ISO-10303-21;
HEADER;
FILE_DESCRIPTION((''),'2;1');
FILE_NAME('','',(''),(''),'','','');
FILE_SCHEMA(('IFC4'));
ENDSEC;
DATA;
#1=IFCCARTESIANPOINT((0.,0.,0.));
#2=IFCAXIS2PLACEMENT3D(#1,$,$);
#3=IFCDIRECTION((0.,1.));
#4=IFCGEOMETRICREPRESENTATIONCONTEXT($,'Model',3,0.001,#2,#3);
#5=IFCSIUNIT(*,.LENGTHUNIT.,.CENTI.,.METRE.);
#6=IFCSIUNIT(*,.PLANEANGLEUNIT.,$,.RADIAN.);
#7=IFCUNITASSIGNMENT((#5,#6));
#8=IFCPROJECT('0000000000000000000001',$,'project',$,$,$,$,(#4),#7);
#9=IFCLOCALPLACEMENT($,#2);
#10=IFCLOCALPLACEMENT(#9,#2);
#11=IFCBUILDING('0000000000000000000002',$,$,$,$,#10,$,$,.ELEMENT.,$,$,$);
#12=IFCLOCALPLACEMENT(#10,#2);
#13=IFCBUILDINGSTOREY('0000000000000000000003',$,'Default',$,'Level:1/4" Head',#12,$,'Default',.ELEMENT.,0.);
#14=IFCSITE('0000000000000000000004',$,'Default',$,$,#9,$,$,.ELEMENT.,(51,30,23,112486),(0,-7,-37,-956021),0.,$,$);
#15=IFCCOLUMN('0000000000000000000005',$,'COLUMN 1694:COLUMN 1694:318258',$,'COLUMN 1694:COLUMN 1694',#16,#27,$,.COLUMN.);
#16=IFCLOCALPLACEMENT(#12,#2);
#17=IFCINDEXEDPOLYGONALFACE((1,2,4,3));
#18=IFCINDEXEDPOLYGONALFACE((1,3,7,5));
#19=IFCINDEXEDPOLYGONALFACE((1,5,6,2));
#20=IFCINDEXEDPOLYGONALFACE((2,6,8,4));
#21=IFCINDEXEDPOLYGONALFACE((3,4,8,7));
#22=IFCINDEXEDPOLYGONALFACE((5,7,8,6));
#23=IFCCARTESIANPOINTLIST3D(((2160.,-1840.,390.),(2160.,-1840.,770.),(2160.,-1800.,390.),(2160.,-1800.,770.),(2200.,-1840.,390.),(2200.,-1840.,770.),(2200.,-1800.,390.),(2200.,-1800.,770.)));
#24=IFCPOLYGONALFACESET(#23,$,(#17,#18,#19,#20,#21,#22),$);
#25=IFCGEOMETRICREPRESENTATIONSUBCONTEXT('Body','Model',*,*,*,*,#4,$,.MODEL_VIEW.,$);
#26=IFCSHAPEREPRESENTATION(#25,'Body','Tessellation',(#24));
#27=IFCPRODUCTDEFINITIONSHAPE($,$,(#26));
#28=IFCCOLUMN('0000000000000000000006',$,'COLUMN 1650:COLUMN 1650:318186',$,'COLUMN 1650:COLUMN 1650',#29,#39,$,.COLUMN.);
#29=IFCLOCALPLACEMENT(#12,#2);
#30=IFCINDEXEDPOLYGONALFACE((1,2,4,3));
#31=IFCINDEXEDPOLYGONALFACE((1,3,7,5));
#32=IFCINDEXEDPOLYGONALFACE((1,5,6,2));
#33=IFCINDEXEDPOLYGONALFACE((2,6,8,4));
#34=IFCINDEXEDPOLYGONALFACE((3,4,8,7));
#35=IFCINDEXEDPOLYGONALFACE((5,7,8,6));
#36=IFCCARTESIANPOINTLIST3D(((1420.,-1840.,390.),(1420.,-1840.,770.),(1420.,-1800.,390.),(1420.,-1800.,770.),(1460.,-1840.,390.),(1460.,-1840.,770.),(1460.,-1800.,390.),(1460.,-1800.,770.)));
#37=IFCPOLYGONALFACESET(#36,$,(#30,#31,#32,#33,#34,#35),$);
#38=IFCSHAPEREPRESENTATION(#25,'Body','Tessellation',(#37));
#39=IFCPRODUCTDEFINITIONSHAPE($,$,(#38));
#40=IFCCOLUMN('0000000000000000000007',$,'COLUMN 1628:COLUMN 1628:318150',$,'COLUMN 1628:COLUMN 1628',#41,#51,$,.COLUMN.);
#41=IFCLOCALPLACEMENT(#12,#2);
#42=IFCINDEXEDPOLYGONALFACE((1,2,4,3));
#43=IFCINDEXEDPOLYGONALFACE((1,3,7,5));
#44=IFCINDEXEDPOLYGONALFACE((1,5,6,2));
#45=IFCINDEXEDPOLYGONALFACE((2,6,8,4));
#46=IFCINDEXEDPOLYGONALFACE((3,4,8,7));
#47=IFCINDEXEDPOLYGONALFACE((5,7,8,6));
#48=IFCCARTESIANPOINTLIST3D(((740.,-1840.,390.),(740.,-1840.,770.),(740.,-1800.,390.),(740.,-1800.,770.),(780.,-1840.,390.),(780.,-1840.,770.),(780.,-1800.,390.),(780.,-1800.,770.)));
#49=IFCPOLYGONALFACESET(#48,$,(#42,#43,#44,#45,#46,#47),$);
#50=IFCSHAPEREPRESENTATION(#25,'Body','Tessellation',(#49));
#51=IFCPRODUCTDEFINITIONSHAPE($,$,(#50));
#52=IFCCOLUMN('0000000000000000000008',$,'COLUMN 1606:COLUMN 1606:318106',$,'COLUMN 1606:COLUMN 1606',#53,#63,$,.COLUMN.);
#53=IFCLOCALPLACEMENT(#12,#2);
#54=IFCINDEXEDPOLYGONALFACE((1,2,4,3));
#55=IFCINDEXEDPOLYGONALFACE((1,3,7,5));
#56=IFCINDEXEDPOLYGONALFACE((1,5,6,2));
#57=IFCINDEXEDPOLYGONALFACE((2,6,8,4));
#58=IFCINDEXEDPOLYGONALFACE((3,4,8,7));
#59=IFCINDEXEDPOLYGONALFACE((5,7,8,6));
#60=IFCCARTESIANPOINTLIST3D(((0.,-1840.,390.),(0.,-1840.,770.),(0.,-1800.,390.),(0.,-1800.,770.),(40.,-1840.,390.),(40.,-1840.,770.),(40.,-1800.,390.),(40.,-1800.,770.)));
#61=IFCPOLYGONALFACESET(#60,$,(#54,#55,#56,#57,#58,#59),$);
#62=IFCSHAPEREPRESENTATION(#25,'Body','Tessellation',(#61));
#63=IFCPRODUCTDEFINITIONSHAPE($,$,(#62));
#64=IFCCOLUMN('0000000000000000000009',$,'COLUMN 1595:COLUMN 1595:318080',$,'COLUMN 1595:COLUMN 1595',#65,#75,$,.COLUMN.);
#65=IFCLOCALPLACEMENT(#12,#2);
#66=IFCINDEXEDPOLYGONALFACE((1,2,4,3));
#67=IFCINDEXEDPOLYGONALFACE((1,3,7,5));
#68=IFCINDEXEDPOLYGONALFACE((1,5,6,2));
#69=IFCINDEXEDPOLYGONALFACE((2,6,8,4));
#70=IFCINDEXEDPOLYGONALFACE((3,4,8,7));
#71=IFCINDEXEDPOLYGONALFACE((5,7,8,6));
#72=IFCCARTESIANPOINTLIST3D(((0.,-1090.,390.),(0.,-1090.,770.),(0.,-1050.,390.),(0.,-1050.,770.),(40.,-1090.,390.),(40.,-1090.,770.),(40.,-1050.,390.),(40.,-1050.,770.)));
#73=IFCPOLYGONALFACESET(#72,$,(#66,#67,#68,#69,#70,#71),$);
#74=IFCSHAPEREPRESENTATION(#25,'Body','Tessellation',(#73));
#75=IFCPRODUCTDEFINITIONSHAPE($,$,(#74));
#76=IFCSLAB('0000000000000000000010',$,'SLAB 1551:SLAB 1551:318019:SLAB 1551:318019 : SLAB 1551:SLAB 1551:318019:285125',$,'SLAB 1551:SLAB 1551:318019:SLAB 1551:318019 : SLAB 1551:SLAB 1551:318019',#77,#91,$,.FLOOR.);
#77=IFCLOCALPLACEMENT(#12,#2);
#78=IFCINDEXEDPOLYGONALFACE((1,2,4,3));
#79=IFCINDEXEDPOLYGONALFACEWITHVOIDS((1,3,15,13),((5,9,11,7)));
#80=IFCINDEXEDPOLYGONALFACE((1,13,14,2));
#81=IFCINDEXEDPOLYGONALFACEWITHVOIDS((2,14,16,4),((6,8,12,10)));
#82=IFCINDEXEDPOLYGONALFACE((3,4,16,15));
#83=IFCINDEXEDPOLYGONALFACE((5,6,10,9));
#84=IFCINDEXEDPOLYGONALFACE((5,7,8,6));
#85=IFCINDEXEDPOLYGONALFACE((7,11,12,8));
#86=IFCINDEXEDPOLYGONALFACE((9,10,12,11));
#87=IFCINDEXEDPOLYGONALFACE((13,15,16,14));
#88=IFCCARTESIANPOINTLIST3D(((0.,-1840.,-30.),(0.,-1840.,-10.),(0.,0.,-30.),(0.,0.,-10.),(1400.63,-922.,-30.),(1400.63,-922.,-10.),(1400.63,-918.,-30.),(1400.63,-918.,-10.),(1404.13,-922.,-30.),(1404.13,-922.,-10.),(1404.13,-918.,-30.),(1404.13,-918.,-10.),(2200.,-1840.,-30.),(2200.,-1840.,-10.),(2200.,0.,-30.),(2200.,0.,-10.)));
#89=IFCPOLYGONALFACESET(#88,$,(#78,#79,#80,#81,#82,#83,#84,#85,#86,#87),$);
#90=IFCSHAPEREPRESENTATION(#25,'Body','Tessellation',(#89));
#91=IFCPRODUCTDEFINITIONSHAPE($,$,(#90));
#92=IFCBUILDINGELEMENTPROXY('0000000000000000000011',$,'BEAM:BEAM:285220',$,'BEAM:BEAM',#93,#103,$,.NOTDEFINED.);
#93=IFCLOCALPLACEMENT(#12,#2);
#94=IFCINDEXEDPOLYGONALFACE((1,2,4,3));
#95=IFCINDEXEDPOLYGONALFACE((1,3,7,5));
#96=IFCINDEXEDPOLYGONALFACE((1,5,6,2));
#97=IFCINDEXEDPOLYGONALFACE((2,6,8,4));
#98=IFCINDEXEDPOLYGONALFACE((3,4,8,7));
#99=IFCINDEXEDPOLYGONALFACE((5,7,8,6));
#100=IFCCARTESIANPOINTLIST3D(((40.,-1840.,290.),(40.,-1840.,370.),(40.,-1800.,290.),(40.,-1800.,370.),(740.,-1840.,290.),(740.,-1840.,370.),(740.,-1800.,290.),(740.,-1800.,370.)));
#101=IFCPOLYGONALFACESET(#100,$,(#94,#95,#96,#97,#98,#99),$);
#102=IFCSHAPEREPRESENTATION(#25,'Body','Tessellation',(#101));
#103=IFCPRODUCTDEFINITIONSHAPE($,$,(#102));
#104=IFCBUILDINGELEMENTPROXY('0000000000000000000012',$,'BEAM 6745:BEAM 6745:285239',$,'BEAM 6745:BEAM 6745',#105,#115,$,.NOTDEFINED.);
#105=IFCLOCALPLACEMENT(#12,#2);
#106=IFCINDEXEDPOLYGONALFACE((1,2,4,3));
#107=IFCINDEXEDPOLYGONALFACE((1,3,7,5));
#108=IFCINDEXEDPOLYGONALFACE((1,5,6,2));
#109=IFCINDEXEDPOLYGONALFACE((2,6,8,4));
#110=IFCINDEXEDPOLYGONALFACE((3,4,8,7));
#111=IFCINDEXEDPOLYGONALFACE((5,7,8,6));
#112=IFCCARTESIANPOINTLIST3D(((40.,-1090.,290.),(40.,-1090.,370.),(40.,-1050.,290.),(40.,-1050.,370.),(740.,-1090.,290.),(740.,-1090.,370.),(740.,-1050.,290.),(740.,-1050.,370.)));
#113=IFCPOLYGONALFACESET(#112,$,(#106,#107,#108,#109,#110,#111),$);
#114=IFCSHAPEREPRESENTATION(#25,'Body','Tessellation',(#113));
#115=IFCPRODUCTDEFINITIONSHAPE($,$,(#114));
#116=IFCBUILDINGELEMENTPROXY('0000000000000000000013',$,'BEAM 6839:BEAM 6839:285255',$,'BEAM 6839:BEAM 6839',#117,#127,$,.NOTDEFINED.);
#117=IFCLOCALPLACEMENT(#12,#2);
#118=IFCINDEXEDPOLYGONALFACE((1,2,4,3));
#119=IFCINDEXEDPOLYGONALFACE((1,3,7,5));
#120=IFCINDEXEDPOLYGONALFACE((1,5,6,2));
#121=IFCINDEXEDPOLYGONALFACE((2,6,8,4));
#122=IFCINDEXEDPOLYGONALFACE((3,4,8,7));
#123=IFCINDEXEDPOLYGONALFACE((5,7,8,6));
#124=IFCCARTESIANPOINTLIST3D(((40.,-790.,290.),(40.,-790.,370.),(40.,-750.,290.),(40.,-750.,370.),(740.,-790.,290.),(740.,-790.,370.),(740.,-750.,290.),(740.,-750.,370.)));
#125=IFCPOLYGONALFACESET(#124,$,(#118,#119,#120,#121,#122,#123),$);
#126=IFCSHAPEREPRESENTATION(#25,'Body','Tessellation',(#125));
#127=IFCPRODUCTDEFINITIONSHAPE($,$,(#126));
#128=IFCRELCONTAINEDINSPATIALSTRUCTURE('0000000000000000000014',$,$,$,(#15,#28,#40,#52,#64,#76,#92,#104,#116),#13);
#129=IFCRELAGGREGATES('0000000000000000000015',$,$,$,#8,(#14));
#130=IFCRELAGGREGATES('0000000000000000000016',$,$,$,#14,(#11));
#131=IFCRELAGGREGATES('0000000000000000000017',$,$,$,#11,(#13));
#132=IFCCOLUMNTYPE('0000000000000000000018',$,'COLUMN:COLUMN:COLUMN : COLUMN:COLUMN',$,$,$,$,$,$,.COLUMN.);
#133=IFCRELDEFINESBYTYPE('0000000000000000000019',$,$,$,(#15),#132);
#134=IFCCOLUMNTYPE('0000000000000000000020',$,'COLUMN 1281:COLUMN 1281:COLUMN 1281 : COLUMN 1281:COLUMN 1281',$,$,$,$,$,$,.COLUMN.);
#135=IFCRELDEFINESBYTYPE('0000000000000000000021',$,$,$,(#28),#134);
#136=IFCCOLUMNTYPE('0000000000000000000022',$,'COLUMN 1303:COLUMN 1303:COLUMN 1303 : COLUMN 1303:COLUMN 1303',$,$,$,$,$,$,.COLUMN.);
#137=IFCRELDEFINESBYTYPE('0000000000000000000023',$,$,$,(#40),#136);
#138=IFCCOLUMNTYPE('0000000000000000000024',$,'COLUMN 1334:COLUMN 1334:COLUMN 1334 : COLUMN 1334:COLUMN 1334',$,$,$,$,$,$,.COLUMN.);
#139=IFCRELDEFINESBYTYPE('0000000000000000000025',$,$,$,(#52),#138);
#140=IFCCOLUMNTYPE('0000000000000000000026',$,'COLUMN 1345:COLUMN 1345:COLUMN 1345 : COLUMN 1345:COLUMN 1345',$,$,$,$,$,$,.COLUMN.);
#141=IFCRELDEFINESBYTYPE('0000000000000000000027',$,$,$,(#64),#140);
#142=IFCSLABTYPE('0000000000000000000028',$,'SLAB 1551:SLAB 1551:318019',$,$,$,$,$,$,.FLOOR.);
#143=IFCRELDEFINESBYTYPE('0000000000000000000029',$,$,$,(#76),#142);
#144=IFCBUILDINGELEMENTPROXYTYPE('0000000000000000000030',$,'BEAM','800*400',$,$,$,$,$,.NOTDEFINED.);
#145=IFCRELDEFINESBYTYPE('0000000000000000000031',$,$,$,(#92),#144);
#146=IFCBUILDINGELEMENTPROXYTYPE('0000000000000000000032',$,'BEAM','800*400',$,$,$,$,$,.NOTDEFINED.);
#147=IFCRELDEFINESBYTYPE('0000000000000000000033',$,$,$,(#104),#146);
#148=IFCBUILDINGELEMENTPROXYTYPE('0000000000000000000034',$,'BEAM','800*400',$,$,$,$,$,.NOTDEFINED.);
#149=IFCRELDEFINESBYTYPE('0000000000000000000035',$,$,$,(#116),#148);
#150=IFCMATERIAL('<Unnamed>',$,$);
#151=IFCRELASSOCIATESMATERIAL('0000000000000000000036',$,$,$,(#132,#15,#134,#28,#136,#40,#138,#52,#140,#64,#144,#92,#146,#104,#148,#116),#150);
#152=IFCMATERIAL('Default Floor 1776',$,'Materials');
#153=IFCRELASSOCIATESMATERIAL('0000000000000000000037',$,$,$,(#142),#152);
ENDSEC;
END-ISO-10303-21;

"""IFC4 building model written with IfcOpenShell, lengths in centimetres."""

from ifc_helpers import new_model, si_unit, direction, frame, frame_2d, origin, origin_2d_with_axis, place, context, subcontext, project, spatial, polyline, segment, composite_curve, rectangle, outline, extrude, source, transform, mapped, material, material_profile, profile_set, profile_usage, type_object, type_shapes, element, save


model = new_model("IFC4")

# Units and contexts
model_context = context("Model", 3, precision=0.001, world=origin(), true_north=direction((0.0, 1.0)))
body_context = subcontext(model_context, "Body", "Model", "MODEL_VIEW")
ifc_project = project(units=[si_unit("LENGTHUNIT", "METRE", prefix="CENTI"), si_unit("PLANEANGLEUNIT", "RADIAN")], contexts=[model_context])

# Site, building, storey
site_placement = place(None, origin())
site = spatial("IfcSite", under=ifc_project, at=site_placement, Name="Default", CompositionType="ELEMENT", RefLatitude=(51, 30, 23, 112486), RefLongitude=(0, -7, -37, -956021), RefElevation=0.0)
building_placement = place(site_placement, origin())
building = spatial("IfcBuilding", under=site, at=building_placement, CompositionType="ELEMENT")
storey_placement = place(building_placement, origin())
storey = spatial("IfcBuildingStorey", under=building, at=storey_placement, Name="Default", ObjectType="Level:1/4\" Head", LongName="Default", CompositionType="ELEMENT", Elevation=0.0)

# Columns
ifc_material_1 = material(Name="<Unnamed>")
ifc_material_profile_1 = material_profile(ifc_material_1, outline(composite_curve([segment(polyline([(2140.0, -20.0, 770.0), (2180.0, -20.0, 770.0)]), True, "CONTINUOUS"), segment(polyline([(2180.0, -20.0, 770.0), (2180.0, 20.0, 770.0)]), True, "CONTINUOUS"), segment(polyline([(2180.0, 20.0, 770.0), (2140.0, 20.0, 770.0)]), True, "CONTINUOUS"), segment(polyline([(2140.0, 20.0, 770.0), (2140.0, -20.0, 770.0)]), True, "CONTINUOUS")], self_intersect=False), kind="CURVE"), Name="COLUMN : COLUMN:COLUMN")
ifc_profile_set_1 = profile_set([ifc_material_profile_1], Name="COLUMN : COLUMN:COLUMN")
ifc_profile_usage_1 = profile_usage(ifc_profile_set_1)
column_type_1 = type_object("IfcColumnType", Name="COLUMN:COLUMN:COLUMN : COLUMN:COLUMN", PredefinedType="COLUMN", material=ifc_profile_set_1)
shared_shape_1 = source(origin(), body_context, "Body", "SweptSolid", [
    extrude(rectangle(XDim=40.0, YDim=40.0, at=frame_2d((0.0, 0.0), x_axis=(1.0, 0.0))), frame((2160.0, 0.0, 390.0), z_axis=(0.0, 0.0, 1.0), x_axis=(0.0, -1.0, 0.0)), (0.0, 0.0, 1.0), 380.0),
])
type_shapes(column_type_1, [shared_shape_1])
column_1_placement = place(storey_placement, frame((20.0, -1820.0, 0.0)))
element("IfcColumn", 1, at=column_1_placement, inside=storey, type_object=column_type_1, material=ifc_profile_usage_1, Name="COLUMN 1694:COLUMN 1694:318258", ObjectType="COLUMN 1694:COLUMN 1694", PredefinedType="COLUMN", context=body_context, shape_type="MappedRepresentation", body=[
    mapped(shared_shape_1, transform((0.0, 0.0, 0.0), scale=1.0)),
])
ifc_material_profile_2 = material_profile(ifc_material_1, outline(composite_curve([segment(polyline([(1400.0, -20.0, 770.0), (1440.0, -20.0, 770.0)]), True, "CONTINUOUS"), segment(polyline([(1440.0, -20.0, 770.0), (1440.0, 20.0, 770.0)]), True, "CONTINUOUS"), segment(polyline([(1440.0, 20.0, 770.0), (1400.0, 20.0, 770.0)]), True, "CONTINUOUS"), segment(polyline([(1400.0, 20.0, 770.0), (1400.0, -20.0, 770.0)]), True, "CONTINUOUS")], self_intersect=False), kind="CURVE"), Name="COLUMN 1281 : COLUMN 1281:COLUMN 1281")
ifc_profile_set_2 = profile_set([ifc_material_profile_2], Name="COLUMN 1281 : COLUMN 1281:COLUMN 1281")
ifc_profile_usage_2 = profile_usage(ifc_profile_set_2)
column_type_2 = type_object("IfcColumnType", Name="COLUMN 1281:COLUMN 1281:COLUMN 1281 : COLUMN 1281:COLUMN 1281", PredefinedType="COLUMN", material=ifc_profile_set_2)
shared_shape_2 = source(origin(), body_context, "Body", "SweptSolid", [
    extrude(rectangle(XDim=40.0, YDim=40.0, at=origin_2d_with_axis()), frame((1420.0, 0.0, 390.0), z_axis=(0.0, 0.0, 1.0), x_axis=(0.0, -1.0, 0.0)), (0.0, 0.0, 1.0), 380.0),
])
type_shapes(column_type_2, [shared_shape_2])
column_2_placement = place(storey_placement, frame((20.0, -1820.0, 0.0)))
element("IfcColumn", 2, at=column_2_placement, inside=storey, type_object=column_type_2, material=ifc_profile_usage_2, Name="COLUMN 1650:COLUMN 1650:318186", ObjectType="COLUMN 1650:COLUMN 1650", PredefinedType="COLUMN", context=body_context, shape_type="MappedRepresentation", body=[
    mapped(shared_shape_2, transform((0.0, 0.0, 0.0), scale=1.0)),
])
ifc_material_profile_3 = material_profile(ifc_material_1, outline(composite_curve([segment(polyline([(720.0, -20.0, 390.0), (720.0, 20.0, 390.0)]), True, "CONTINUOUS"), segment(polyline([(720.0, 20.0, 390.0), (760.0, 20.0, 390.0)]), True, "CONTINUOUS"), segment(polyline([(760.0, 20.0, 390.0), (760.0, -20.0, 390.0)]), True, "CONTINUOUS"), segment(polyline([(760.0, -20.0, 390.0), (720.0, -20.0, 390.0)]), True, "CONTINUOUS")], self_intersect=False), kind="CURVE"), Name="COLUMN 1303 : COLUMN 1303:COLUMN 1303")
ifc_profile_set_3 = profile_set([ifc_material_profile_3], Name="COLUMN 1303 : COLUMN 1303:COLUMN 1303")
ifc_profile_usage_3 = profile_usage(ifc_profile_set_3)
column_type_3 = type_object("IfcColumnType", Name="COLUMN 1303:COLUMN 1303:COLUMN 1303 : COLUMN 1303:COLUMN 1303", PredefinedType="COLUMN", material=ifc_profile_set_3)
shared_shape_3 = source(origin(), body_context, "Body", "SweptSolid", [
    extrude(rectangle(XDim=40.0, YDim=40.0, at=origin_2d_with_axis()), frame((740.0, 0.0, 390.0), z_axis=(0.0, 0.0, 1.0), x_axis=(0.0, -1.0, 0.0)), (0.0, 0.0, 1.0), 380.0),
])
type_shapes(column_type_3, [shared_shape_3])
column_3_placement = place(storey_placement, frame((20.0, -1820.0, 0.0)))
element("IfcColumn", 3, at=column_3_placement, inside=storey, type_object=column_type_3, material=ifc_profile_usage_3, Name="COLUMN 1628:COLUMN 1628:318150", ObjectType="COLUMN 1628:COLUMN 1628", PredefinedType="COLUMN", context=body_context, shape_type="MappedRepresentation", body=[
    mapped(shared_shape_3, transform((0.0, 0.0, 0.0), scale=1.0)),
])
ifc_material_profile_4 = material_profile(ifc_material_1, outline(composite_curve([segment(polyline([(-20.0, -20.0, 390.0), (-20.0, 20.0, 390.0)]), True, "CONTINUOUS"), segment(polyline([(-20.0, 20.0, 390.0), (20.0, 20.0, 390.0)]), True, "CONTINUOUS"), segment(polyline([(20.0, 20.0, 390.0), (20.0, -20.0, 390.0)]), True, "CONTINUOUS"), segment(polyline([(20.0, -20.0, 390.0), (-20.0, -20.0, 390.0)]), True, "CONTINUOUS")], self_intersect=False), kind="CURVE"), Name="COLUMN 1334 : COLUMN 1334:COLUMN 1334")
ifc_profile_set_4 = profile_set([ifc_material_profile_4], Name="COLUMN 1334 : COLUMN 1334:COLUMN 1334")
ifc_profile_usage_4 = profile_usage(ifc_profile_set_4)
column_type_4 = type_object("IfcColumnType", Name="COLUMN 1334:COLUMN 1334:COLUMN 1334 : COLUMN 1334:COLUMN 1334", PredefinedType="COLUMN", material=ifc_profile_set_4)
shared_shape_4 = source(origin(), body_context, "Body", "SweptSolid", [
    extrude(rectangle(XDim=40.0, YDim=40.0, at=origin_2d_with_axis()), frame((0.0, 0.0, 390.0), z_axis=(0.0, 0.0, 1.0), x_axis=(0.0, -1.0, 0.0)), (0.0, 0.0, 1.0), 380.0),
])
type_shapes(column_type_4, [shared_shape_4])
column_4_placement = place(storey_placement, frame((20.0, -1820.0, 0.0)))
element("IfcColumn", 4, at=column_4_placement, inside=storey, type_object=column_type_4, material=ifc_profile_usage_4, Name="COLUMN 1606:COLUMN 1606:318106", ObjectType="COLUMN 1606:COLUMN 1606", PredefinedType="COLUMN", context=body_context, shape_type="MappedRepresentation", body=[
    mapped(shared_shape_4, transform((0.0, 0.0, 0.0), scale=1.0)),
])
ifc_material_profile_5 = material_profile(ifc_material_1, outline(composite_curve([segment(polyline([(-20.0, 730.0, 390.0), (-20.0, 770.0, 390.0)]), True, "CONTINUOUS"), segment(polyline([(-20.0, 770.0, 390.0), (20.0, 770.0, 390.0)]), True, "CONTINUOUS"), segment(polyline([(20.0, 770.0, 390.0), (20.0, 730.0, 390.0)]), True, "CONTINUOUS"), segment(polyline([(20.0, 730.0, 390.0), (-20.0, 730.0, 390.0)]), True, "CONTINUOUS")], self_intersect=False), kind="CURVE"), Name="COLUMN 1345 : COLUMN 1345:COLUMN 1345")
ifc_profile_set_5 = profile_set([ifc_material_profile_5], Name="COLUMN 1345 : COLUMN 1345:COLUMN 1345")
ifc_profile_usage_5 = profile_usage(ifc_profile_set_5)
column_type_5 = type_object("IfcColumnType", Name="COLUMN 1345:COLUMN 1345:COLUMN 1345 : COLUMN 1345:COLUMN 1345", PredefinedType="COLUMN", material=ifc_profile_set_5)
shared_shape_5 = source(origin(), body_context, "Body", "SweptSolid", [
    extrude(rectangle(XDim=40.0, YDim=40.0, at=origin_2d_with_axis()), frame((0.0, 750.0, 390.0), z_axis=(0.0, 0.0, 1.0), x_axis=(0.0, -1.0, 0.0)), (0.0, 0.0, 1.0), 380.0),
])
type_shapes(column_type_5, [shared_shape_5])
column_5_placement = place(storey_placement, frame((20.0, -1820.0, 0.0)))
element("IfcColumn", 5, at=column_5_placement, inside=storey, type_object=column_type_5, material=ifc_profile_usage_5, Name="COLUMN 1595:COLUMN 1595:318080", ObjectType="COLUMN 1595:COLUMN 1595", PredefinedType="COLUMN", context=body_context, shape_type="MappedRepresentation", body=[
    mapped(shared_shape_5, transform((0.0, 0.0, 0.0), scale=1.0)),
])

# Slab
ifc_material_2 = material(Name="Default Floor 1776", Category="Materials")
slab_type_1 = type_object("IfcSlabType", Name="SLAB 1551:SLAB 1551:318019", PredefinedType="FLOOR", material=ifc_material_2)
slab_1_placement = place(storey_placement, frame((0.0, -1840.0, -30.0)))
element("IfcSlab", 6, at=slab_1_placement, inside=storey, type_object=slab_type_1, Name="SLAB 1551:SLAB 1551:318019:SLAB 1551:318019 : SLAB 1551:SLAB 1551:318019:285125", ObjectType="SLAB 1551:SLAB 1551:318019:SLAB 1551:318019 : SLAB 1551:SLAB 1551:318019", PredefinedType="FLOOR", context=body_context, shape_type="SweptSolid", body=[
    extrude(outline(polyline([(-920.0, -1100.0), (920.0, -1100.0), (920.0, 1100.0), (-920.0, 1100.0), (-920.0, -1100.0)]), holes=[polyline([(2.0, 300.63), (-2.0, 300.63), (-2.0, 304.13), (2.0, 304.13), (2.0, 300.63)])]), frame((1100.0, 920.0, 0.0), z_axis=(0.0, 0.0, 1.0), x_axis=(0.0, -1.0, 0.0)), (0.0, 0.0, 1.0), 20.0),
])

# Building element proxies
building_element_proxy_type_1 = type_object("IfcBuildingElementProxyType", Name="BEAM", Description="800*400", PredefinedType="NOTDEFINED", material=ifc_material_1)
shared_shape_6 = source(origin(), body_context, "Body", "SweptSolid", [
    extrude(rectangle(XDim=40.0, YDim=700.0, at=origin_2d_with_axis()), frame((350.0, 20.0, 0.0), z_axis=(0.0, 0.0, 1.0), x_axis=(0.0, 1.0, 0.0)), (0.0, 0.0, 1.0), 80.0),
])
type_shapes(building_element_proxy_type_1, [shared_shape_6])
proxy_1_placement = place(storey_placement, frame((40.0, -1840.0, 290.0)))
element("IfcBuildingElementProxy", 7, at=proxy_1_placement, inside=storey, type_object=building_element_proxy_type_1, material=ifc_material_1, Name="BEAM:BEAM:285220", ObjectType="BEAM:BEAM", PredefinedType="NOTDEFINED", context=body_context, shape_type="MappedRepresentation", body=[
    mapped(shared_shape_6, transform((0.0, 0.0, 0.0), scale=1.0)),
])
building_element_proxy_type_2 = type_object("IfcBuildingElementProxyType", Name="BEAM", Description="800*400", PredefinedType="NOTDEFINED", material=ifc_material_1)
shared_shape_7 = source(origin(), body_context, "Body", "SweptSolid", [
    extrude(rectangle(XDim=40.0, YDim=700.0, at=origin_2d_with_axis()), frame((350.0, 20.0, 0.0), z_axis=(0.0, 0.0, 1.0), x_axis=(0.0, 1.0, 0.0)), (0.0, 0.0, 1.0), 80.0),
])
type_shapes(building_element_proxy_type_2, [shared_shape_7])
proxy_2_placement = place(storey_placement, frame((40.0, -1090.0, 290.0)))
element("IfcBuildingElementProxy", 8, at=proxy_2_placement, inside=storey, type_object=building_element_proxy_type_2, material=ifc_material_1, Name="BEAM 6745:BEAM 6745:285239", ObjectType="BEAM 6745:BEAM 6745", PredefinedType="NOTDEFINED", context=body_context, shape_type="MappedRepresentation", body=[
    mapped(shared_shape_7, transform((0.0, 0.0, 0.0), scale=1.0)),
])
building_element_proxy_type_3 = type_object("IfcBuildingElementProxyType", Name="BEAM", Description="800*400", PredefinedType="NOTDEFINED", material=ifc_material_1)
shared_shape_8 = source(origin(), body_context, "Body", "SweptSolid", [
    extrude(rectangle(XDim=40.0, YDim=700.0, at=origin_2d_with_axis()), frame((350.0, 20.0, 0.0), z_axis=(0.0, 0.0, 1.0), x_axis=(0.0, 1.0, 0.0)), (0.0, 0.0, 1.0), 80.0),
])
type_shapes(building_element_proxy_type_3, [shared_shape_8])
proxy_3_placement = place(storey_placement, frame((40.0, -790.0, 290.0)))
element("IfcBuildingElementProxy", 9, at=proxy_3_placement, inside=storey, type_object=building_element_proxy_type_3, material=ifc_material_1, Name="BEAM 6839:BEAM 6839:285255", ObjectType="BEAM 6839:BEAM 6839", PredefinedType="NOTDEFINED", context=body_context, shape_type="MappedRepresentation", body=[
    mapped(shared_shape_8, transform((0.0, 0.0, 0.0), scale=1.0)),
])

save(model, "model.ifc")
